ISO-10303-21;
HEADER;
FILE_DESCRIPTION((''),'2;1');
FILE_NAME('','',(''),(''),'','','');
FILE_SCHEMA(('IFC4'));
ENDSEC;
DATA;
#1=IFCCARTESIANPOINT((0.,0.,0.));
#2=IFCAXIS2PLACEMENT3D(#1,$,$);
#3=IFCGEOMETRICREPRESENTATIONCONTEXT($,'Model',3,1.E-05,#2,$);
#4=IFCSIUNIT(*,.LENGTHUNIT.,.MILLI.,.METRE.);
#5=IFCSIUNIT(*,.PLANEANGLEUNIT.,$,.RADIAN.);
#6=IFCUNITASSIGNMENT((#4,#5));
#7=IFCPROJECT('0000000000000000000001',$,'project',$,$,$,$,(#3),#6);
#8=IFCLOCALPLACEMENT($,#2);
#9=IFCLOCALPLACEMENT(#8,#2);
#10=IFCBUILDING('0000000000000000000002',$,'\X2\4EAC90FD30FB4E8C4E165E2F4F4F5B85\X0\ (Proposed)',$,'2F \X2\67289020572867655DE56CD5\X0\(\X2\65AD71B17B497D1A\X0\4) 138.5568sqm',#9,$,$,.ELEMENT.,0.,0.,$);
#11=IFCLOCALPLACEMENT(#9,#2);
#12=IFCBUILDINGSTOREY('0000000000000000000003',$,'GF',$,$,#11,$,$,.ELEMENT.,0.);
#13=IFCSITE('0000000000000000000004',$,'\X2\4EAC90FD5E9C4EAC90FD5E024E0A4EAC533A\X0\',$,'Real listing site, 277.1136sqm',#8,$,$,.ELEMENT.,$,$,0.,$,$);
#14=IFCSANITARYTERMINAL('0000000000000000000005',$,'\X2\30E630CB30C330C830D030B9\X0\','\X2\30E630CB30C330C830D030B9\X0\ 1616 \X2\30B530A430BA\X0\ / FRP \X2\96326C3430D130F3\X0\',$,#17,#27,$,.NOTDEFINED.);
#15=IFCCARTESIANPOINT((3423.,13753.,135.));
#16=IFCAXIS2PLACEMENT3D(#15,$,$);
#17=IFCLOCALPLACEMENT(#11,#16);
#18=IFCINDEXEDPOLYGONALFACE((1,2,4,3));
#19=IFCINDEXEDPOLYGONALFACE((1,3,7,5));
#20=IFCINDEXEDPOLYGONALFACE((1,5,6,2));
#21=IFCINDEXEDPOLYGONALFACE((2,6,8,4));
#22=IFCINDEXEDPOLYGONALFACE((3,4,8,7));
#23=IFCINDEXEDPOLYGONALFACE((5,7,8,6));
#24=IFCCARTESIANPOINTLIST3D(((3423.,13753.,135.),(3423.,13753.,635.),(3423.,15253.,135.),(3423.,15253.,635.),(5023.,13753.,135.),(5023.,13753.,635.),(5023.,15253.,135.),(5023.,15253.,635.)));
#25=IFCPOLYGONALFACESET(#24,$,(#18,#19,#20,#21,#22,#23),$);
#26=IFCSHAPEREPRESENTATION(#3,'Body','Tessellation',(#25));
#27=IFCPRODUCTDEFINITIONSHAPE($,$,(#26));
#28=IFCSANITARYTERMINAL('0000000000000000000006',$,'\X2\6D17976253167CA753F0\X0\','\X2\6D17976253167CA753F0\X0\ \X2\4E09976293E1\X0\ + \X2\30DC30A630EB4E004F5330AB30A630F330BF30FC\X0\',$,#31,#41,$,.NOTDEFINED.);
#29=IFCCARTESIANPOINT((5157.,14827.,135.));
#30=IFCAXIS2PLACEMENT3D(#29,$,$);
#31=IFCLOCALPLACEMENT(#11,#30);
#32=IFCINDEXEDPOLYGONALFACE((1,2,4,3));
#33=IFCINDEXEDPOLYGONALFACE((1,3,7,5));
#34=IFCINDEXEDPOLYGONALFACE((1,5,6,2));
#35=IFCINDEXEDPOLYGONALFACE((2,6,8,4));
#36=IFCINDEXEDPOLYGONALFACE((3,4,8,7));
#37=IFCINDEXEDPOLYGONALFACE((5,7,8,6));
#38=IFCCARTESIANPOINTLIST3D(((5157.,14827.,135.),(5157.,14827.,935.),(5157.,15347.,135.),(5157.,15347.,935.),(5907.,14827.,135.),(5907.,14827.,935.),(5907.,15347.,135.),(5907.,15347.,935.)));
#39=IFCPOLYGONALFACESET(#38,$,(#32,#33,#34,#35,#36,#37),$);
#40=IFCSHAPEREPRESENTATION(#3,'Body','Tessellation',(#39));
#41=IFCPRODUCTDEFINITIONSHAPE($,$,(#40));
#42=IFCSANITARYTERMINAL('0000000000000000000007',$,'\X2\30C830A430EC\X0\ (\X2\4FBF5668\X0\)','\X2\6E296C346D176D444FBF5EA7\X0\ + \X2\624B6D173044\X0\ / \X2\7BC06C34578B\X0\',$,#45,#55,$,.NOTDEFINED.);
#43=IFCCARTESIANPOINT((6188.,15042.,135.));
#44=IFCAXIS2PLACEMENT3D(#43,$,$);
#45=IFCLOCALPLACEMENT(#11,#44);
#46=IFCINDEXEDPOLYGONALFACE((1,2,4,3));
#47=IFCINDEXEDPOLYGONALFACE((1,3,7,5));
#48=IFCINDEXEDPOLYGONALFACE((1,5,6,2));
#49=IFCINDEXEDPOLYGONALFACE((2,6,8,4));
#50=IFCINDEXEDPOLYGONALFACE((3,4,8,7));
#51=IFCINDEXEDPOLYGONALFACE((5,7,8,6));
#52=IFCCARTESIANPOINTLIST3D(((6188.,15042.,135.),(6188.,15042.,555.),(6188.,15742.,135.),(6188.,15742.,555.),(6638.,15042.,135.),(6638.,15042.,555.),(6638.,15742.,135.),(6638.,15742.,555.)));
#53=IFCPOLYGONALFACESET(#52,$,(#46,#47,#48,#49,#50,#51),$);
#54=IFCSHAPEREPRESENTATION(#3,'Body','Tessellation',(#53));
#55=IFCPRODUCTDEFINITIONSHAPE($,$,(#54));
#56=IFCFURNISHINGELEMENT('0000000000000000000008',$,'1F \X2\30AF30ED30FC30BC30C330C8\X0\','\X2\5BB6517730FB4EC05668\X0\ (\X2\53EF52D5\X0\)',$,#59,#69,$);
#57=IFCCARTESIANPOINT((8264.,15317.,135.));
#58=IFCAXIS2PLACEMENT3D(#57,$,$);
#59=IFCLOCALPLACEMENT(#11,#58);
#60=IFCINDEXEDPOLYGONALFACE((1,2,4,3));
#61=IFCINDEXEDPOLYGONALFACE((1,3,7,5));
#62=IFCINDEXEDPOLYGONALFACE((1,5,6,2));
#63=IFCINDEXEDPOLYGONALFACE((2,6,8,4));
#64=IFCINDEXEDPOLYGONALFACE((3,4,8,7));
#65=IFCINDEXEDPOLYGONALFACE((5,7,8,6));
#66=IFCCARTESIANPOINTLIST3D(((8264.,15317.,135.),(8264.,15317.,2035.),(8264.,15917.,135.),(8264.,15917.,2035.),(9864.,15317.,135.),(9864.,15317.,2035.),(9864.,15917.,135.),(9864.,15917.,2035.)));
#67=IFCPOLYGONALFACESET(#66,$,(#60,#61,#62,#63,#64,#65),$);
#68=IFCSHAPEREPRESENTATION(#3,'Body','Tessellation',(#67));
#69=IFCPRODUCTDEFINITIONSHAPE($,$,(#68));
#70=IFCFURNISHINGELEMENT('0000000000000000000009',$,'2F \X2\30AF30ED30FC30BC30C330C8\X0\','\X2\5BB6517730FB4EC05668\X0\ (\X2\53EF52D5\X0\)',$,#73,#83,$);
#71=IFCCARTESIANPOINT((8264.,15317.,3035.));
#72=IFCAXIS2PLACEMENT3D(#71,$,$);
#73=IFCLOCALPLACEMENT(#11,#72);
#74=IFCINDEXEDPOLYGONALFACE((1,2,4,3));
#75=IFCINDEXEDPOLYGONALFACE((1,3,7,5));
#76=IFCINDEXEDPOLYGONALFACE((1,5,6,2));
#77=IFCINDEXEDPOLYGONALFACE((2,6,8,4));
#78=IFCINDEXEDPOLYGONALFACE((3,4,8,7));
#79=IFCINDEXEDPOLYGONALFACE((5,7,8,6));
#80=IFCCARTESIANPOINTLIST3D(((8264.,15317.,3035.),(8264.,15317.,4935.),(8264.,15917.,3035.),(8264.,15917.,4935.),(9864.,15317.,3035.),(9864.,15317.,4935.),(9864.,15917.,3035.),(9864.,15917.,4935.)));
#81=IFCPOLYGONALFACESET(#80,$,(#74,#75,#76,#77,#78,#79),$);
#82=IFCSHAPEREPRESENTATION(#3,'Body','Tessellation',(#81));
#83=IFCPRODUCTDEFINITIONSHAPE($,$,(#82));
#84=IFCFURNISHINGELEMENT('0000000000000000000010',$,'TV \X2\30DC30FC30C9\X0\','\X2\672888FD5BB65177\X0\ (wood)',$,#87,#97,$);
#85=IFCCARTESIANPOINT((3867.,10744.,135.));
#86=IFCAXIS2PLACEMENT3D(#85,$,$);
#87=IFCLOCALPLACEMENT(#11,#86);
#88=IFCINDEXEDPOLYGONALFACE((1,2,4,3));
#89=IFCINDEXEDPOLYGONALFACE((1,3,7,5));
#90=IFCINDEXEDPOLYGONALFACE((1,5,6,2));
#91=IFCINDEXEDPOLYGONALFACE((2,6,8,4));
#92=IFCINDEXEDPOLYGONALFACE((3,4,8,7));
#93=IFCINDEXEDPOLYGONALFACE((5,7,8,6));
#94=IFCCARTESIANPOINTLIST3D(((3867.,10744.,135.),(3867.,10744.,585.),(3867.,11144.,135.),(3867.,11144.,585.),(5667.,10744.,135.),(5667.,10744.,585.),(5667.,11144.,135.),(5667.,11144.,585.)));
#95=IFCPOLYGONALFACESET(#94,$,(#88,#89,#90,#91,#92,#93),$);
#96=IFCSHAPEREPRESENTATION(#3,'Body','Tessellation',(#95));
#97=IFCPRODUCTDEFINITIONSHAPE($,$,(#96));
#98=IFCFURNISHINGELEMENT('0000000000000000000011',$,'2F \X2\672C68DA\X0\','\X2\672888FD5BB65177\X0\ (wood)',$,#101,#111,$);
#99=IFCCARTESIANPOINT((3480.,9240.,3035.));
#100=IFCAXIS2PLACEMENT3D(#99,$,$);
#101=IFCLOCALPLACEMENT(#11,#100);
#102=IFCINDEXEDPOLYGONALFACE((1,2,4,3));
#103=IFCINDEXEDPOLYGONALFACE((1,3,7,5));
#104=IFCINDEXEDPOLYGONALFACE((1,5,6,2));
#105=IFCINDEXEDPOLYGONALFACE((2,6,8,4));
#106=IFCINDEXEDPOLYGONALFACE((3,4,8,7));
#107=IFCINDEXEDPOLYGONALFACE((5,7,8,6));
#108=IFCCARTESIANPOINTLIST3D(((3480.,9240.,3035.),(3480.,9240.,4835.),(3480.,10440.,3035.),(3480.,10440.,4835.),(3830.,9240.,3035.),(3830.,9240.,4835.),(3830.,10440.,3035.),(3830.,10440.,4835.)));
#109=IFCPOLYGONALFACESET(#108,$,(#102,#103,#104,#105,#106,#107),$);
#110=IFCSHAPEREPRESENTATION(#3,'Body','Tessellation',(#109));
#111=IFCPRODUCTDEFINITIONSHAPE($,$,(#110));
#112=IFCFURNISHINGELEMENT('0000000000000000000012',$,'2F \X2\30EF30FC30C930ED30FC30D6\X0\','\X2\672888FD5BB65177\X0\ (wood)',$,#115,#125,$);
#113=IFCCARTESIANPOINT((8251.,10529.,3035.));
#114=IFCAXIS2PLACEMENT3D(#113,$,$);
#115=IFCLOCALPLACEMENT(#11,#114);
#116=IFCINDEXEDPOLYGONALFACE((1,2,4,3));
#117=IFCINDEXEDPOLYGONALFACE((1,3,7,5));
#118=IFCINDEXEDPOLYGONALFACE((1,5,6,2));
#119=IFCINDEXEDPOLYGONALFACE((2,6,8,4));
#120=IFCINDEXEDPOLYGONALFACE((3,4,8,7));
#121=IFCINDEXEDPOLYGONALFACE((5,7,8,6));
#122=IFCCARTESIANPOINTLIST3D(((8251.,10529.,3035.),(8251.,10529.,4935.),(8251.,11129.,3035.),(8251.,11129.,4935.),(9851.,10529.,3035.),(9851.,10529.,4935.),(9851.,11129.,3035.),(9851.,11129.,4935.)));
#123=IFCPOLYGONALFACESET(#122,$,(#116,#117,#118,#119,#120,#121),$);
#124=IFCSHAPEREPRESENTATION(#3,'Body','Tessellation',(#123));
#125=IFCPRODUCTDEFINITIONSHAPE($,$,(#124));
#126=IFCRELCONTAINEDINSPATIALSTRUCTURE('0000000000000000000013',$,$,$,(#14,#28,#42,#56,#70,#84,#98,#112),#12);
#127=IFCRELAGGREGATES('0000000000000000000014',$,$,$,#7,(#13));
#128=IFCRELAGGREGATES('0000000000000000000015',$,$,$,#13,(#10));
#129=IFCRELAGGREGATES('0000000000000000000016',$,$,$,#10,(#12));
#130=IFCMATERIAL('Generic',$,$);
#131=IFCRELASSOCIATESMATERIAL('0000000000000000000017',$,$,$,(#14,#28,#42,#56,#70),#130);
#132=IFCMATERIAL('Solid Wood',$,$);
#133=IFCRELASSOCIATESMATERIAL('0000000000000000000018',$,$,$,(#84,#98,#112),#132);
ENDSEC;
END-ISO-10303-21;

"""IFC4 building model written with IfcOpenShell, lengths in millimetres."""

from ifc_helpers import new_model, si_unit, frame, frame_2d, origin, place, context, project, spatial, rectangle, extrude, material, element, save


model = new_model("IFC4")

# Units and contexts
model_context = context("Model", 3, precision=1e-05, world=origin())
ifc_project = project(units=[si_unit("LENGTHUNIT", "METRE", prefix="MILLI"), si_unit("PLANEANGLEUNIT", "RADIAN")], contexts=[model_context])

# Site, building, storey
site_placement = place(None, origin())
site = spatial("IfcSite", under=ifc_project, at=site_placement, Name="京都府京都市上京区", ObjectType="Real listing site, 277.1136sqm", CompositionType="ELEMENT", RefElevation=0.0)
building_placement = place(site_placement, origin())
building = spatial("IfcBuilding", under=site, at=building_placement, Name="京都・二世帯住宅 (Proposed)", ObjectType="2F 木造在来工法(断熱等級4) 138.5568sqm", CompositionType="ELEMENT", ElevationOfRefHeight=0.0, ElevationOfTerrain=0.0)
storey_placement = place(building_placement, origin())
storey = spatial("IfcBuildingStorey", under=building, at=storey_placement, Name="GF", CompositionType="ELEMENT", Elevation=0.0)

# Shared definitions
ifc_material_1 = material(Name="Solid Wood")

# Shared definitions
ifc_material_2 = material(Name="Generic")

# Sanitary terminals
sanitary_terminal_1_placement = place(storey_placement, frame((3423.0, 13753.0, 135.0)))
element("IfcSanitaryTerminal", 1, at=sanitary_terminal_1_placement, inside=storey, material=ifc_material_2, Name="ユニットバス", Description="ユニットバス 1616 サイズ / FRP 防水パン", PredefinedType="NOTDEFINED", context=model_context, shape_type="SweptSolid", body=[
    extrude(rectangle(XDim=1600.0, YDim=1500.0, at=frame_2d((800.0, 750.0))), frame((3423.0, 13753.0, 135.0)), (0.0, 0.0, 1.0), 500.0),
])
sanitary_terminal_2_placement = place(storey_placement, frame((5157.0, 14827.0, 135.0)))
element("IfcSanitaryTerminal", 2, at=sanitary_terminal_2_placement, inside=storey, material=ifc_material_2, Name="洗面化粧台", Description="洗面化粧台 三面鏡 + ボウル一体カウンター", PredefinedType="NOTDEFINED", context=model_context, shape_type="SweptSolid", body=[
    extrude(rectangle(XDim=750.0, YDim=520.0, at=frame_2d((375.0, 260.0))), frame((5157.0, 14827.0, 135.0)), (0.0, 0.0, 1.0), 800.0),
])
sanitary_terminal_3_placement = place(storey_placement, frame((6188.0, 15042.0, 135.0)))
element("IfcSanitaryTerminal", 3, at=sanitary_terminal_3_placement, inside=storey, material=ifc_material_2, Name="トイレ (便器)", Description="温水洗浄便座 + 手洗い / 節水型", PredefinedType="NOTDEFINED", context=model_context, shape_type="SweptSolid", body=[
    extrude(rectangle(XDim=450.0, YDim=700.0, at=frame_2d((225.0, 350.0))), frame((6188.0, 15042.0, 135.0)), (0.0, 0.0, 1.0), 420.0),
])

# Furnishing elements
furnishing_1_placement = place(storey_placement, frame((8264.0, 15317.0, 135.0)))
element("IfcFurnishingElement", 4, at=furnishing_1_placement, inside=storey, material=ifc_material_2, Name="1F クローゼット", Description="家具・什器 (可動)", context=model_context, shape_type="SweptSolid", body=[
    extrude(rectangle(XDim=1600.0, YDim=600.0, at=frame_2d((800.0, 300.0))), frame((8264.0, 15317.0, 135.0)), (0.0, 0.0, 1.0), 1900.0),
])
furnishing_2_placement = place(storey_placement, frame((8264.0, 15317.0, 3035.0)))
element("IfcFurnishingElement", 5, at=furnishing_2_placement, inside=storey, material=ifc_material_2, Name="2F クローゼット", Description="家具・什器 (可動)", context=model_context, shape_type="SweptSolid", body=[
    extrude(rectangle(XDim=1600.0, YDim=600.0, at=frame_2d((800.0, 300.0))), frame((8264.0, 15317.0, 3035.0)), (0.0, 0.0, 1.0), 1900.0),
])
furnishing_3_placement = place(storey_placement, frame((3867.0, 10744.0, 135.0)))
element("IfcFurnishingElement", 6, at=furnishing_3_placement, inside=storey, material=ifc_material_1, Name="TV ボード", Description="木製家具 (wood)", context=model_context, shape_type="SweptSolid", body=[
    extrude(rectangle(XDim=1800.0, YDim=400.0, at=frame_2d((900.0, 200.0))), frame((3867.0, 10744.0, 135.0)), (0.0, 0.0, 1.0), 450.0),
])
furnishing_4_placement = place(storey_placement, frame((3480.0, 9240.0, 3035.0)))
element("IfcFurnishingElement", 7, at=furnishing_4_placement, inside=storey, material=ifc_material_1, Name="2F 本棚", Description="木製家具 (wood)", context=model_context, shape_type="SweptSolid", body=[
    extrude(rectangle(XDim=350.0, YDim=1200.0, at=frame_2d((175.0, 600.0))), frame((3480.0, 9240.0, 3035.0)), (0.0, 0.0, 1.0), 1800.0),
])
furnishing_5_placement = place(storey_placement, frame((8251.0, 10529.0, 3035.0)))
element("IfcFurnishingElement", 8, at=furnishing_5_placement, inside=storey, material=ifc_material_1, Name="2F ワードローブ", Description="木製家具 (wood)", context=model_context, shape_type="SweptSolid", body=[
    extrude(rectangle(XDim=1600.0, YDim=600.0, at=frame_2d((800.0, 300.0))), frame((8251.0, 10529.0, 3035.0)), (0.0, 0.0, 1.0), 1900.0),
])

save(model, "model.ifc")
